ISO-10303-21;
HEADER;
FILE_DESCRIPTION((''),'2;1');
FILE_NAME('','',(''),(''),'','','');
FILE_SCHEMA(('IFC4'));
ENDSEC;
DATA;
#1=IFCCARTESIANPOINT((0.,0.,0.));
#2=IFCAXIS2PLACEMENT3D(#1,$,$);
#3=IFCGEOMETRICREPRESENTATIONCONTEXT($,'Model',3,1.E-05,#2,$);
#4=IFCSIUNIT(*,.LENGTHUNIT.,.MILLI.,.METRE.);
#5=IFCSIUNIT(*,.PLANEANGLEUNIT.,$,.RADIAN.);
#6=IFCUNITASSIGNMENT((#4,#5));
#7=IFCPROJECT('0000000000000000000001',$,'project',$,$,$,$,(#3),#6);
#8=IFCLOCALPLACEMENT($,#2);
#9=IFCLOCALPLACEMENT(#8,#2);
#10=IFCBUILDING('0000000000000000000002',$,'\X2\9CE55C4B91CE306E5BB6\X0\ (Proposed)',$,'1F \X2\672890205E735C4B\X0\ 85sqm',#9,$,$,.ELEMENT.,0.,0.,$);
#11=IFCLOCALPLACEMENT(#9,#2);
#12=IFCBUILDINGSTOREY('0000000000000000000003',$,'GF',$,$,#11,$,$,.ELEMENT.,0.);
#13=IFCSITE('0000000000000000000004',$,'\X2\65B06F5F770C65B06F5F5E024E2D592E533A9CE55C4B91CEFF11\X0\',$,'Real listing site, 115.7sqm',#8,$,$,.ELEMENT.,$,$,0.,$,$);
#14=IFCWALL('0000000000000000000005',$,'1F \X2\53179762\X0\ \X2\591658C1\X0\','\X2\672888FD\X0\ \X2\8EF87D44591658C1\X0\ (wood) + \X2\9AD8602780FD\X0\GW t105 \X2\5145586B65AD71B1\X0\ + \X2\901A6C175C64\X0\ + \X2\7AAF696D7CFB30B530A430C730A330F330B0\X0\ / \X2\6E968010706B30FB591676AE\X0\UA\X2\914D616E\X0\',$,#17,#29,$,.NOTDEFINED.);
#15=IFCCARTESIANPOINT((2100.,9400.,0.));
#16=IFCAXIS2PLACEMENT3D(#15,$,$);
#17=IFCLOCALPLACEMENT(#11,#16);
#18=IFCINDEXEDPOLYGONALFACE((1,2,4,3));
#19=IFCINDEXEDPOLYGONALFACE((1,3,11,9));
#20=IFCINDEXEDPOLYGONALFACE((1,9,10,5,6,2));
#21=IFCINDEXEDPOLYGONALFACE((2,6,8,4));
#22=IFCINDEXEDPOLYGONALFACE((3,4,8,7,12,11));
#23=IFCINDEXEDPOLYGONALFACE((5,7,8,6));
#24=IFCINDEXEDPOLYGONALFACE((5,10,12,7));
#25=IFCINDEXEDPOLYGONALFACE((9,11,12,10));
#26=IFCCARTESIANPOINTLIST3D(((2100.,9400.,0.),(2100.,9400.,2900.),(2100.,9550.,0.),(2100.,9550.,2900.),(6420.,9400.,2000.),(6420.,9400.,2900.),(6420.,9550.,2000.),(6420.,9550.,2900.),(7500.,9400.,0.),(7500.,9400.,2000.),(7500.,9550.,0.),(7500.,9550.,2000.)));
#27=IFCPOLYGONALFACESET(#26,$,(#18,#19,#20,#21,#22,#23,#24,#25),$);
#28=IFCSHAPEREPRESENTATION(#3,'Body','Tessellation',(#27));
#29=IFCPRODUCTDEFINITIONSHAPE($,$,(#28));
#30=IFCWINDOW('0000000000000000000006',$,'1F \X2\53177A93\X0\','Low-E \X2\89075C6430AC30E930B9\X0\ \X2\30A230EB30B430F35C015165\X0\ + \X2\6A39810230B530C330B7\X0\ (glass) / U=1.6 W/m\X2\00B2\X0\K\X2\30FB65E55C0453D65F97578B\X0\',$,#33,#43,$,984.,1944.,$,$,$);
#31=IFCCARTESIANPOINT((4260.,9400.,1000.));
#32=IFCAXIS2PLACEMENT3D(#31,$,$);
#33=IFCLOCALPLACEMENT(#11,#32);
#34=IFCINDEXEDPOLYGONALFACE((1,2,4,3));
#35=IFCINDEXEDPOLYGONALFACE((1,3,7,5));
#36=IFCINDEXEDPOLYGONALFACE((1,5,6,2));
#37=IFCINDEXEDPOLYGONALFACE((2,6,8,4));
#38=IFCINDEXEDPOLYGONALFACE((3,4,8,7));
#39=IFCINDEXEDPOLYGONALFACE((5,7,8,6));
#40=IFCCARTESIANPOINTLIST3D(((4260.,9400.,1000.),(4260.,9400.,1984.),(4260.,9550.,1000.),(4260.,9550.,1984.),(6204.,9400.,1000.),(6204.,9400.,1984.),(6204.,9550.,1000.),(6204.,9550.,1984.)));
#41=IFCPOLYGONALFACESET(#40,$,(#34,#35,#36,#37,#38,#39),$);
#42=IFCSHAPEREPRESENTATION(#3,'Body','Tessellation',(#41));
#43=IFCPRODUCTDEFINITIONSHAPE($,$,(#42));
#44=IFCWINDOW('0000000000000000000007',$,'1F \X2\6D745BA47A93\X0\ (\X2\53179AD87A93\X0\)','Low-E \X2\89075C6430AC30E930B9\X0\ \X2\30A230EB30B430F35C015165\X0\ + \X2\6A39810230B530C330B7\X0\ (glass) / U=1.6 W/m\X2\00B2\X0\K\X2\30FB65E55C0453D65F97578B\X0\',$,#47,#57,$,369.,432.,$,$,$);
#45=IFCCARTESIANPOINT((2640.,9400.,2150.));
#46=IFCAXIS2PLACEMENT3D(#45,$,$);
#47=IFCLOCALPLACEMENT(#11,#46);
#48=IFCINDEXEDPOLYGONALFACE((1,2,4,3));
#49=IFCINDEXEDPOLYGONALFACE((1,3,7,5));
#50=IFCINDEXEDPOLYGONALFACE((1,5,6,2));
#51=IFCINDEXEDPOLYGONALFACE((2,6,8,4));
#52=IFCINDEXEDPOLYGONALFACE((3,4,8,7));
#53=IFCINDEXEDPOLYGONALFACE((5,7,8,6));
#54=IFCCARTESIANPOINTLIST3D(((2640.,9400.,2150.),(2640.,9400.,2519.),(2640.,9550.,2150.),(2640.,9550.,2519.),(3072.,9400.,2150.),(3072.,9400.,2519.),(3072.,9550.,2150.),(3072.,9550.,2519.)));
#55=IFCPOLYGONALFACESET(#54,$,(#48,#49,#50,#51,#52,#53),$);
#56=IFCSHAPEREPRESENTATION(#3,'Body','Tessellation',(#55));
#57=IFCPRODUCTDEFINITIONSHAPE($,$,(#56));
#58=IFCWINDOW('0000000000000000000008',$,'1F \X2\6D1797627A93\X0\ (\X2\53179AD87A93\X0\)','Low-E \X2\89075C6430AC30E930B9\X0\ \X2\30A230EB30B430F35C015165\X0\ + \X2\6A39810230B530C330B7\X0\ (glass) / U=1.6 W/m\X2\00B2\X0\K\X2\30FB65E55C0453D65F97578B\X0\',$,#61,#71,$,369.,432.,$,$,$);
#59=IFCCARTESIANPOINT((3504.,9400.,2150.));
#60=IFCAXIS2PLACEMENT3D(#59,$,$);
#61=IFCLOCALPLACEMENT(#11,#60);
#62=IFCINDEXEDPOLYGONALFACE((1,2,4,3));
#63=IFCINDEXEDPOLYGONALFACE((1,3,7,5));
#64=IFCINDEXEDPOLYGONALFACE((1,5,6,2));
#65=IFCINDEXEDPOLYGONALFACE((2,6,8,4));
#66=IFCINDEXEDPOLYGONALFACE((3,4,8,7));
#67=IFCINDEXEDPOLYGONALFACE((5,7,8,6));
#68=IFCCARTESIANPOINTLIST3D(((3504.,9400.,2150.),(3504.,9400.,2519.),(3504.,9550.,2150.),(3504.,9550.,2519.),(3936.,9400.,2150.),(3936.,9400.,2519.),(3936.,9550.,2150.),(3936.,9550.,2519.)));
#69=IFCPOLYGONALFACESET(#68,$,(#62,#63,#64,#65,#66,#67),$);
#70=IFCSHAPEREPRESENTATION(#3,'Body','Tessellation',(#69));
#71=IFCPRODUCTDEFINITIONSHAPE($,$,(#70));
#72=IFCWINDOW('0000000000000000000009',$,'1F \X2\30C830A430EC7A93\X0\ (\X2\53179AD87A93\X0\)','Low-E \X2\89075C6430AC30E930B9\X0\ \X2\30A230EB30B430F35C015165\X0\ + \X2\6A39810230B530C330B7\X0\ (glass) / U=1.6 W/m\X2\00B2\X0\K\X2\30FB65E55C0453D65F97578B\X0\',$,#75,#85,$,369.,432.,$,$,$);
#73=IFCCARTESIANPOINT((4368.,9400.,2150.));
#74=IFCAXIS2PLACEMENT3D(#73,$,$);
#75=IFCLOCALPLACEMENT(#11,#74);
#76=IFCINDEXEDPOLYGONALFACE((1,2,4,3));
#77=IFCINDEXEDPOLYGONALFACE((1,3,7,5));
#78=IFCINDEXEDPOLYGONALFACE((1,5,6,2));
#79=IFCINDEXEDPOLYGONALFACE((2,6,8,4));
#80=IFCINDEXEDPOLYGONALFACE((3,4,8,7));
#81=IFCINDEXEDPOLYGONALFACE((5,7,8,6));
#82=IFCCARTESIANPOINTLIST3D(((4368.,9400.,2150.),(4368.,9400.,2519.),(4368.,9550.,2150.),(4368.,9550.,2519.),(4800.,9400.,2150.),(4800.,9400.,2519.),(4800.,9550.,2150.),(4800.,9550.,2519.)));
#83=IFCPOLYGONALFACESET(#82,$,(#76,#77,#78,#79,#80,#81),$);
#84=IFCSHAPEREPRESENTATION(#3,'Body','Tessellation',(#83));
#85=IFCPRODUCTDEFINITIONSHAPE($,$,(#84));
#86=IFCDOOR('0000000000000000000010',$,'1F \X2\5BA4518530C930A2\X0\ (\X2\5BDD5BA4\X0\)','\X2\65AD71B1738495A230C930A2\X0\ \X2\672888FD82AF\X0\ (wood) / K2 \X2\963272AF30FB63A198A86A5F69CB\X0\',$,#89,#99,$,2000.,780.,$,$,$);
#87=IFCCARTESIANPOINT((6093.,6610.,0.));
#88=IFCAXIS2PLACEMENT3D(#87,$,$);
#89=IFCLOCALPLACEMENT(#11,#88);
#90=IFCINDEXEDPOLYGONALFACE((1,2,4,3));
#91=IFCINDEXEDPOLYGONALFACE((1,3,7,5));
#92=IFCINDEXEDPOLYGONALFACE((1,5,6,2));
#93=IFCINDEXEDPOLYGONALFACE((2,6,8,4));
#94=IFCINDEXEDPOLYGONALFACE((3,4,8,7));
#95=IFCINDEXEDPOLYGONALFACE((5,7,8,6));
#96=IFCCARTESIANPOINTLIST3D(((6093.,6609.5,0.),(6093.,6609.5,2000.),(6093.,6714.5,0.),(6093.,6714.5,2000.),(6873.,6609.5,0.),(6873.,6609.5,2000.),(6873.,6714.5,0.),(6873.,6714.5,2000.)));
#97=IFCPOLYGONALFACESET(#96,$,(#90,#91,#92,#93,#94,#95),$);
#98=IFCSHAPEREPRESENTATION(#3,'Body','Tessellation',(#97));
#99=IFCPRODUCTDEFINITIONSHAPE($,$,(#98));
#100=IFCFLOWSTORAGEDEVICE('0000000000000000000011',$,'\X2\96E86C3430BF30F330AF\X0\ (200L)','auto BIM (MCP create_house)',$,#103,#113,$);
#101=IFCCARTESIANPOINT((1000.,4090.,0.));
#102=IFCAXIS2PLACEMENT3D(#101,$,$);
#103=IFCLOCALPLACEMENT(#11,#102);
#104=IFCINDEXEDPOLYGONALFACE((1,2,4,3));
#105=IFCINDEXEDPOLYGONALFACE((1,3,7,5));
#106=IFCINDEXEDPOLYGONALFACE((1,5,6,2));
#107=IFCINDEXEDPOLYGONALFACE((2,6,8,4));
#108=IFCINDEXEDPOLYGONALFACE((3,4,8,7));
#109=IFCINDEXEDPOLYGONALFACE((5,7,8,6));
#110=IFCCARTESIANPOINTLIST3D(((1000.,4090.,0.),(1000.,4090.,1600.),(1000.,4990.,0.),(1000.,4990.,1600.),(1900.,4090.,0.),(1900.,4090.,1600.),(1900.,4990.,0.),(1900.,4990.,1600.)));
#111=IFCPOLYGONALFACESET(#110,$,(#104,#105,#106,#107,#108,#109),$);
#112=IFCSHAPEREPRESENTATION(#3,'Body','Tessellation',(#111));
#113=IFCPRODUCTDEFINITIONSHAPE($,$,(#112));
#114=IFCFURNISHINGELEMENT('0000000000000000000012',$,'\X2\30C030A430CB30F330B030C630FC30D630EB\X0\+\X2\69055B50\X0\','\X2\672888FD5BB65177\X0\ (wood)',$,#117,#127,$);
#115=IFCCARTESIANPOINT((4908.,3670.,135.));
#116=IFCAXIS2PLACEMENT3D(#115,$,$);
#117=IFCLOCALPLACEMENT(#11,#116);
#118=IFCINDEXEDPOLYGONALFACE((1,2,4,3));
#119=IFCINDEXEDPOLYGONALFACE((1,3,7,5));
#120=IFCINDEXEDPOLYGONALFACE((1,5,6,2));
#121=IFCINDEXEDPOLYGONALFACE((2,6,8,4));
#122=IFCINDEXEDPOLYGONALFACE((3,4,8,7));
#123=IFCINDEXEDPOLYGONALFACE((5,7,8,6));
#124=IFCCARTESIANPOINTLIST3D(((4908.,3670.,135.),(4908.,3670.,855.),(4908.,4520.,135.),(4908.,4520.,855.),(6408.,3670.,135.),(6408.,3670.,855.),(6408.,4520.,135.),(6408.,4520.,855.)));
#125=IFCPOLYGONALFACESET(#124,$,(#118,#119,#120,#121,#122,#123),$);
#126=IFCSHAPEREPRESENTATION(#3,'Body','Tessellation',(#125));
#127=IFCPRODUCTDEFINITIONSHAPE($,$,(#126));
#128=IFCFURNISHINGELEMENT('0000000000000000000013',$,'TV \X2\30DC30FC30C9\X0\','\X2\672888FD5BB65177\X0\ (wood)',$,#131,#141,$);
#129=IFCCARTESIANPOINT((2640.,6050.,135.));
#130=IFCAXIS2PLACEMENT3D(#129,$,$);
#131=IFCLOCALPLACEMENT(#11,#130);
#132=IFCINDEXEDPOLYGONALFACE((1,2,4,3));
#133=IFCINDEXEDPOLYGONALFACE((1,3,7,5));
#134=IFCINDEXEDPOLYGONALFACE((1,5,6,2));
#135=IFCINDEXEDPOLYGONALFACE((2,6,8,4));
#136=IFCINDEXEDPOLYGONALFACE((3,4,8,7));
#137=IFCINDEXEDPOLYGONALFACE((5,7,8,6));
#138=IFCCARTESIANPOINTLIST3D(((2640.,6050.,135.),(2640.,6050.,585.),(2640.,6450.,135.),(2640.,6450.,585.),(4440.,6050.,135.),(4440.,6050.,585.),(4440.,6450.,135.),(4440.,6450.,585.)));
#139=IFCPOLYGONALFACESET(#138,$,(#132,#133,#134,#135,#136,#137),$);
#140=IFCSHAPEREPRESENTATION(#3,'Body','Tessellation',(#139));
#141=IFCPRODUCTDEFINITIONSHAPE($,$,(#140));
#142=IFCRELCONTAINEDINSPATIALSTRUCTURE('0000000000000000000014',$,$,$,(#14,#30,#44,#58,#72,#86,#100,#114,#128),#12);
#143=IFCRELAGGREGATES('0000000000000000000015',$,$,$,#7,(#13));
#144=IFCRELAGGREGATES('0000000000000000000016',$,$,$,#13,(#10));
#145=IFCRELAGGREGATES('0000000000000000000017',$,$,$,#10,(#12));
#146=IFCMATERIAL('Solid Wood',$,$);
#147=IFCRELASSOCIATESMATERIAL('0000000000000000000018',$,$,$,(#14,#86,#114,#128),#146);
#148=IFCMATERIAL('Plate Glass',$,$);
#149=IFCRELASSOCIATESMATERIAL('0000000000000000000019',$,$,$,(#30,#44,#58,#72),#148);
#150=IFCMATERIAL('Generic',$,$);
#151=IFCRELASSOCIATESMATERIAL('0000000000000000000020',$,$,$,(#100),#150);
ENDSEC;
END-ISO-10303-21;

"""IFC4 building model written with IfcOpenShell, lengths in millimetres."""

from ifc_helpers import new_model, si_unit, frame, frame_2d, origin, place, context, project, spatial, rectangle, extrude, material, element, fill, save


model = new_model("IFC4")

# Units and contexts
model_context = context("Model", 3, precision=1e-05, world=origin())
ifc_project = project(units=[si_unit("LENGTHUNIT", "METRE", prefix="MILLI"), si_unit("PLANEANGLEUNIT", "RADIAN")], contexts=[model_context])

# Site, building, storey
site_placement = place(None, origin())
site = spatial("IfcSite", under=ifc_project, at=site_placement, Name="新潟県新潟市中央区鳥屋野１", ObjectType="Real listing site, 115.7sqm", CompositionType="ELEMENT", RefElevation=0.0)
building_placement = place(site_placement, origin())
building = spatial("IfcBuilding", under=site, at=building_placement, Name="鳥屋野の家 (Proposed)", ObjectType="1F 木造平屋 85sqm", CompositionType="ELEMENT", ElevationOfRefHeight=0.0, ElevationOfTerrain=0.0)
storey_placement = place(building_placement, origin())
storey = spatial("IfcBuildingStorey", under=building, at=storey_placement, Name="GF", CompositionType="ELEMENT", Elevation=0.0)

# Wall, openings, windows
ifc_material_1 = material(Name="Solid Wood")
wall_1_placement = place(storey_placement, frame((2100.0, 9400.0, 0.0)))
wall_1 = element("IfcWall", 1, at=wall_1_placement, inside=storey, material=ifc_material_1, Name="1F 北面 外壁", Description="木製 軸組外壁 (wood) + 高性能GW t105 充填断熱 + 通気層 + 窯業系サイディング / 準耐火・外皮UA配慮", PredefinedType="NOTDEFINED", context=model_context, shape_type="SweptSolid", body=[
    extrude(rectangle(XDim=5400.0, YDim=150.0, at=frame_2d((2700.0, 75.0))), frame((2100.0, 9400.0, 0.0)), (0.0, 0.0, 1.0), 2900.0),
])
opening_1_placement = place(storey_placement, frame((4260.0, 9400.0, 1000.0)))
opening_1 = element("IfcOpeningElement", 2, at=opening_1_placement, cuts=wall_1, PredefinedType="NOTDEFINED", context=model_context, shape_type="SweptSolid", body=[
    extrude(rectangle(XDim=1944.0, YDim=150.0, at=frame_2d((972.0, 75.0))), frame((4260.0, 9400.0, 1000.0)), (0.0, 0.0, 1.0), 984.0),
])
opening_2_placement = place(storey_placement, frame((2640.0, 9400.0, 2150.0)))
opening_2 = element("IfcOpeningElement", 3, at=opening_2_placement, cuts=wall_1, PredefinedType="NOTDEFINED", context=model_context, shape_type="SweptSolid", body=[
    extrude(rectangle(XDim=432.0, YDim=150.0, at=frame_2d((216.0, 75.0))), frame((2640.0, 9400.0, 2150.0)), (0.0, 0.0, 1.0), 369.0),
])
opening_3_placement = place(storey_placement, frame((3504.0, 9400.0, 2150.0)))
opening_3 = element("IfcOpeningElement", 4, at=opening_3_placement, cuts=wall_1, PredefinedType="NOTDEFINED", context=model_context, shape_type="SweptSolid", body=[
    extrude(rectangle(XDim=432.0, YDim=150.0, at=frame_2d((216.0, 75.0))), frame((3504.0, 9400.0, 2150.0)), (0.0, 0.0, 1.0), 369.0),
])
opening_4_placement = place(storey_placement, frame((4368.0, 9400.0, 2150.0)))
opening_4 = element("IfcOpeningElement", 5, at=opening_4_placement, cuts=wall_1, PredefinedType="NOTDEFINED", context=model_context, shape_type="SweptSolid", body=[
    extrude(rectangle(XDim=432.0, YDim=150.0, at=frame_2d((216.0, 75.0))), frame((4368.0, 9400.0, 2150.0)), (0.0, 0.0, 1.0), 369.0),
])
ifc_material_2 = material(Name="Plate Glass")
window_1_placement = place(storey_placement, frame((4260.0, 9400.0, 1000.0)))
window_1 = element("IfcWindow", 6, at=window_1_placement, inside=storey, material=ifc_material_2, Name="1F 北窓", Description="Low-E 複層ガラス アルゴン封入 + 樹脂サッシ (glass) / U=1.6 W/m²K・日射取得型", OverallHeight=984.0, OverallWidth=1944.0, context=model_context, shape_type="SweptSolid", body=[
    extrude(rectangle(XDim=1944.0, YDim=150.0, at=frame_2d((972.0, 75.0))), frame((4260.0, 9400.0, 1000.0)), (0.0, 0.0, 1.0), 984.0),
])
fill(opening_1, window_1)
window_2_placement = place(storey_placement, frame((2640.0, 9400.0, 2150.0)))
window_2 = element("IfcWindow", 7, at=window_2_placement, inside=storey, material=ifc_material_2, Name="1F 浴室窓 (北高窓)", Description="Low-E 複層ガラス アルゴン封入 + 樹脂サッシ (glass) / U=1.6 W/m²K・日射取得型", OverallHeight=369.0, OverallWidth=432.0, context=model_context, shape_type="SweptSolid", body=[
    extrude(rectangle(XDim=432.0, YDim=150.0, at=frame_2d((216.0, 75.0))), frame((2640.0, 9400.0, 2150.0)), (0.0, 0.0, 1.0), 369.0),
])
fill(opening_2, window_2)
window_3_placement = place(storey_placement, frame((3504.0, 9400.0, 2150.0)))
window_3 = element("IfcWindow", 8, at=window_3_placement, inside=storey, material=ifc_material_2, Name="1F 洗面窓 (北高窓)", Description="Low-E 複層ガラス アルゴン封入 + 樹脂サッシ (glass) / U=1.6 W/m²K・日射取得型", OverallHeight=369.0, OverallWidth=432.0, context=model_context, shape_type="SweptSolid", body=[
    extrude(rectangle(XDim=432.0, YDim=150.0, at=frame_2d((216.0, 75.0))), frame((3504.0, 9400.0, 2150.0)), (0.0, 0.0, 1.0), 369.0),
])
fill(opening_3, window_3)
window_4_placement = place(storey_placement, frame((4368.0, 9400.0, 2150.0)))
window_4 = element("IfcWindow", 9, at=window_4_placement, inside=storey, material=ifc_material_2, Name="1F トイレ窓 (北高窓)", Description="Low-E 複層ガラス アルゴン封入 + 樹脂サッシ (glass) / U=1.6 W/m²K・日射取得型", OverallHeight=369.0, OverallWidth=432.0, context=model_context, shape_type="SweptSolid", body=[
    extrude(rectangle(XDim=432.0, YDim=150.0, at=frame_2d((216.0, 75.0))), frame((4368.0, 9400.0, 2150.0)), (0.0, 0.0, 1.0), 369.0),
])
fill(opening_4, window_4)

# Door
door_1_placement = place(storey_placement, frame((6093.0, 6610.0, 0.0)))
element("IfcDoor", 10, at=door_1_placement, inside=storey, material=ifc_material_1, Name="1F 室内ドア (寝室)", Description="断熱玄関ドア 木製芯 (wood) / K2 防犯・採風機構", OverallHeight=2000.0, OverallWidth=780.0, context=model_context, shape_type="SweptSolid", body=[
    extrude(rectangle(XDim=780.0, YDim=105.0, at=frame_2d((390.0, 52.0))), frame((6093.0, 6610.0, 0.0)), (0.0, 0.0, 1.0), 2000.0),
])

# Flow storage device
ifc_material_3 = material(Name="Generic")
flow_storage_device_placement = place(storey_placement, frame((1000.0, 4090.0, 0.0)))
element("IfcFlowStorageDevice", 11, at=flow_storage_device_placement, inside=storey, material=ifc_material_3, Name="雨水タンク (200L)", Description="auto BIM (MCP create_house)", context=model_context, shape_type="SweptSolid", body=[
    extrude(rectangle(XDim=900.0, YDim=900.0, at=frame_2d((450.0, 450.0))), frame((1000.0, 4090.0, 0.0)), (0.0, 0.0, 1.0), 1600.0),
])

# Furnishing elements
furnishing_1_placement = place(storey_placement, frame((4908.0, 3670.0, 135.0)))
element("IfcFurnishingElement", 12, at=furnishing_1_placement, inside=storey, material=ifc_material_1, Name="ダイニングテーブル+椅子", Description="木製家具 (wood)", context=model_context, shape_type="SweptSolid", body=[
    extrude(rectangle(XDim=1500.0, YDim=850.0, at=frame_2d((750.0, 425.0))), frame((4908.0, 3670.0, 135.0)), (0.0, 0.0, 1.0), 720.0),
])
furnishing_2_placement = place(storey_placement, frame((2640.0, 6050.0, 135.0)))
element("IfcFurnishingElement", 13, at=furnishing_2_placement, inside=storey, material=ifc_material_1, Name="TV ボード", Description="木製家具 (wood)", context=model_context, shape_type="SweptSolid", body=[
    extrude(rectangle(XDim=1800.0, YDim=400.0, at=frame_2d((900.0, 200.0))), frame((2640.0, 6050.0, 135.0)), (0.0, 0.0, 1.0), 450.0),
])

save(model, "model.ifc")
